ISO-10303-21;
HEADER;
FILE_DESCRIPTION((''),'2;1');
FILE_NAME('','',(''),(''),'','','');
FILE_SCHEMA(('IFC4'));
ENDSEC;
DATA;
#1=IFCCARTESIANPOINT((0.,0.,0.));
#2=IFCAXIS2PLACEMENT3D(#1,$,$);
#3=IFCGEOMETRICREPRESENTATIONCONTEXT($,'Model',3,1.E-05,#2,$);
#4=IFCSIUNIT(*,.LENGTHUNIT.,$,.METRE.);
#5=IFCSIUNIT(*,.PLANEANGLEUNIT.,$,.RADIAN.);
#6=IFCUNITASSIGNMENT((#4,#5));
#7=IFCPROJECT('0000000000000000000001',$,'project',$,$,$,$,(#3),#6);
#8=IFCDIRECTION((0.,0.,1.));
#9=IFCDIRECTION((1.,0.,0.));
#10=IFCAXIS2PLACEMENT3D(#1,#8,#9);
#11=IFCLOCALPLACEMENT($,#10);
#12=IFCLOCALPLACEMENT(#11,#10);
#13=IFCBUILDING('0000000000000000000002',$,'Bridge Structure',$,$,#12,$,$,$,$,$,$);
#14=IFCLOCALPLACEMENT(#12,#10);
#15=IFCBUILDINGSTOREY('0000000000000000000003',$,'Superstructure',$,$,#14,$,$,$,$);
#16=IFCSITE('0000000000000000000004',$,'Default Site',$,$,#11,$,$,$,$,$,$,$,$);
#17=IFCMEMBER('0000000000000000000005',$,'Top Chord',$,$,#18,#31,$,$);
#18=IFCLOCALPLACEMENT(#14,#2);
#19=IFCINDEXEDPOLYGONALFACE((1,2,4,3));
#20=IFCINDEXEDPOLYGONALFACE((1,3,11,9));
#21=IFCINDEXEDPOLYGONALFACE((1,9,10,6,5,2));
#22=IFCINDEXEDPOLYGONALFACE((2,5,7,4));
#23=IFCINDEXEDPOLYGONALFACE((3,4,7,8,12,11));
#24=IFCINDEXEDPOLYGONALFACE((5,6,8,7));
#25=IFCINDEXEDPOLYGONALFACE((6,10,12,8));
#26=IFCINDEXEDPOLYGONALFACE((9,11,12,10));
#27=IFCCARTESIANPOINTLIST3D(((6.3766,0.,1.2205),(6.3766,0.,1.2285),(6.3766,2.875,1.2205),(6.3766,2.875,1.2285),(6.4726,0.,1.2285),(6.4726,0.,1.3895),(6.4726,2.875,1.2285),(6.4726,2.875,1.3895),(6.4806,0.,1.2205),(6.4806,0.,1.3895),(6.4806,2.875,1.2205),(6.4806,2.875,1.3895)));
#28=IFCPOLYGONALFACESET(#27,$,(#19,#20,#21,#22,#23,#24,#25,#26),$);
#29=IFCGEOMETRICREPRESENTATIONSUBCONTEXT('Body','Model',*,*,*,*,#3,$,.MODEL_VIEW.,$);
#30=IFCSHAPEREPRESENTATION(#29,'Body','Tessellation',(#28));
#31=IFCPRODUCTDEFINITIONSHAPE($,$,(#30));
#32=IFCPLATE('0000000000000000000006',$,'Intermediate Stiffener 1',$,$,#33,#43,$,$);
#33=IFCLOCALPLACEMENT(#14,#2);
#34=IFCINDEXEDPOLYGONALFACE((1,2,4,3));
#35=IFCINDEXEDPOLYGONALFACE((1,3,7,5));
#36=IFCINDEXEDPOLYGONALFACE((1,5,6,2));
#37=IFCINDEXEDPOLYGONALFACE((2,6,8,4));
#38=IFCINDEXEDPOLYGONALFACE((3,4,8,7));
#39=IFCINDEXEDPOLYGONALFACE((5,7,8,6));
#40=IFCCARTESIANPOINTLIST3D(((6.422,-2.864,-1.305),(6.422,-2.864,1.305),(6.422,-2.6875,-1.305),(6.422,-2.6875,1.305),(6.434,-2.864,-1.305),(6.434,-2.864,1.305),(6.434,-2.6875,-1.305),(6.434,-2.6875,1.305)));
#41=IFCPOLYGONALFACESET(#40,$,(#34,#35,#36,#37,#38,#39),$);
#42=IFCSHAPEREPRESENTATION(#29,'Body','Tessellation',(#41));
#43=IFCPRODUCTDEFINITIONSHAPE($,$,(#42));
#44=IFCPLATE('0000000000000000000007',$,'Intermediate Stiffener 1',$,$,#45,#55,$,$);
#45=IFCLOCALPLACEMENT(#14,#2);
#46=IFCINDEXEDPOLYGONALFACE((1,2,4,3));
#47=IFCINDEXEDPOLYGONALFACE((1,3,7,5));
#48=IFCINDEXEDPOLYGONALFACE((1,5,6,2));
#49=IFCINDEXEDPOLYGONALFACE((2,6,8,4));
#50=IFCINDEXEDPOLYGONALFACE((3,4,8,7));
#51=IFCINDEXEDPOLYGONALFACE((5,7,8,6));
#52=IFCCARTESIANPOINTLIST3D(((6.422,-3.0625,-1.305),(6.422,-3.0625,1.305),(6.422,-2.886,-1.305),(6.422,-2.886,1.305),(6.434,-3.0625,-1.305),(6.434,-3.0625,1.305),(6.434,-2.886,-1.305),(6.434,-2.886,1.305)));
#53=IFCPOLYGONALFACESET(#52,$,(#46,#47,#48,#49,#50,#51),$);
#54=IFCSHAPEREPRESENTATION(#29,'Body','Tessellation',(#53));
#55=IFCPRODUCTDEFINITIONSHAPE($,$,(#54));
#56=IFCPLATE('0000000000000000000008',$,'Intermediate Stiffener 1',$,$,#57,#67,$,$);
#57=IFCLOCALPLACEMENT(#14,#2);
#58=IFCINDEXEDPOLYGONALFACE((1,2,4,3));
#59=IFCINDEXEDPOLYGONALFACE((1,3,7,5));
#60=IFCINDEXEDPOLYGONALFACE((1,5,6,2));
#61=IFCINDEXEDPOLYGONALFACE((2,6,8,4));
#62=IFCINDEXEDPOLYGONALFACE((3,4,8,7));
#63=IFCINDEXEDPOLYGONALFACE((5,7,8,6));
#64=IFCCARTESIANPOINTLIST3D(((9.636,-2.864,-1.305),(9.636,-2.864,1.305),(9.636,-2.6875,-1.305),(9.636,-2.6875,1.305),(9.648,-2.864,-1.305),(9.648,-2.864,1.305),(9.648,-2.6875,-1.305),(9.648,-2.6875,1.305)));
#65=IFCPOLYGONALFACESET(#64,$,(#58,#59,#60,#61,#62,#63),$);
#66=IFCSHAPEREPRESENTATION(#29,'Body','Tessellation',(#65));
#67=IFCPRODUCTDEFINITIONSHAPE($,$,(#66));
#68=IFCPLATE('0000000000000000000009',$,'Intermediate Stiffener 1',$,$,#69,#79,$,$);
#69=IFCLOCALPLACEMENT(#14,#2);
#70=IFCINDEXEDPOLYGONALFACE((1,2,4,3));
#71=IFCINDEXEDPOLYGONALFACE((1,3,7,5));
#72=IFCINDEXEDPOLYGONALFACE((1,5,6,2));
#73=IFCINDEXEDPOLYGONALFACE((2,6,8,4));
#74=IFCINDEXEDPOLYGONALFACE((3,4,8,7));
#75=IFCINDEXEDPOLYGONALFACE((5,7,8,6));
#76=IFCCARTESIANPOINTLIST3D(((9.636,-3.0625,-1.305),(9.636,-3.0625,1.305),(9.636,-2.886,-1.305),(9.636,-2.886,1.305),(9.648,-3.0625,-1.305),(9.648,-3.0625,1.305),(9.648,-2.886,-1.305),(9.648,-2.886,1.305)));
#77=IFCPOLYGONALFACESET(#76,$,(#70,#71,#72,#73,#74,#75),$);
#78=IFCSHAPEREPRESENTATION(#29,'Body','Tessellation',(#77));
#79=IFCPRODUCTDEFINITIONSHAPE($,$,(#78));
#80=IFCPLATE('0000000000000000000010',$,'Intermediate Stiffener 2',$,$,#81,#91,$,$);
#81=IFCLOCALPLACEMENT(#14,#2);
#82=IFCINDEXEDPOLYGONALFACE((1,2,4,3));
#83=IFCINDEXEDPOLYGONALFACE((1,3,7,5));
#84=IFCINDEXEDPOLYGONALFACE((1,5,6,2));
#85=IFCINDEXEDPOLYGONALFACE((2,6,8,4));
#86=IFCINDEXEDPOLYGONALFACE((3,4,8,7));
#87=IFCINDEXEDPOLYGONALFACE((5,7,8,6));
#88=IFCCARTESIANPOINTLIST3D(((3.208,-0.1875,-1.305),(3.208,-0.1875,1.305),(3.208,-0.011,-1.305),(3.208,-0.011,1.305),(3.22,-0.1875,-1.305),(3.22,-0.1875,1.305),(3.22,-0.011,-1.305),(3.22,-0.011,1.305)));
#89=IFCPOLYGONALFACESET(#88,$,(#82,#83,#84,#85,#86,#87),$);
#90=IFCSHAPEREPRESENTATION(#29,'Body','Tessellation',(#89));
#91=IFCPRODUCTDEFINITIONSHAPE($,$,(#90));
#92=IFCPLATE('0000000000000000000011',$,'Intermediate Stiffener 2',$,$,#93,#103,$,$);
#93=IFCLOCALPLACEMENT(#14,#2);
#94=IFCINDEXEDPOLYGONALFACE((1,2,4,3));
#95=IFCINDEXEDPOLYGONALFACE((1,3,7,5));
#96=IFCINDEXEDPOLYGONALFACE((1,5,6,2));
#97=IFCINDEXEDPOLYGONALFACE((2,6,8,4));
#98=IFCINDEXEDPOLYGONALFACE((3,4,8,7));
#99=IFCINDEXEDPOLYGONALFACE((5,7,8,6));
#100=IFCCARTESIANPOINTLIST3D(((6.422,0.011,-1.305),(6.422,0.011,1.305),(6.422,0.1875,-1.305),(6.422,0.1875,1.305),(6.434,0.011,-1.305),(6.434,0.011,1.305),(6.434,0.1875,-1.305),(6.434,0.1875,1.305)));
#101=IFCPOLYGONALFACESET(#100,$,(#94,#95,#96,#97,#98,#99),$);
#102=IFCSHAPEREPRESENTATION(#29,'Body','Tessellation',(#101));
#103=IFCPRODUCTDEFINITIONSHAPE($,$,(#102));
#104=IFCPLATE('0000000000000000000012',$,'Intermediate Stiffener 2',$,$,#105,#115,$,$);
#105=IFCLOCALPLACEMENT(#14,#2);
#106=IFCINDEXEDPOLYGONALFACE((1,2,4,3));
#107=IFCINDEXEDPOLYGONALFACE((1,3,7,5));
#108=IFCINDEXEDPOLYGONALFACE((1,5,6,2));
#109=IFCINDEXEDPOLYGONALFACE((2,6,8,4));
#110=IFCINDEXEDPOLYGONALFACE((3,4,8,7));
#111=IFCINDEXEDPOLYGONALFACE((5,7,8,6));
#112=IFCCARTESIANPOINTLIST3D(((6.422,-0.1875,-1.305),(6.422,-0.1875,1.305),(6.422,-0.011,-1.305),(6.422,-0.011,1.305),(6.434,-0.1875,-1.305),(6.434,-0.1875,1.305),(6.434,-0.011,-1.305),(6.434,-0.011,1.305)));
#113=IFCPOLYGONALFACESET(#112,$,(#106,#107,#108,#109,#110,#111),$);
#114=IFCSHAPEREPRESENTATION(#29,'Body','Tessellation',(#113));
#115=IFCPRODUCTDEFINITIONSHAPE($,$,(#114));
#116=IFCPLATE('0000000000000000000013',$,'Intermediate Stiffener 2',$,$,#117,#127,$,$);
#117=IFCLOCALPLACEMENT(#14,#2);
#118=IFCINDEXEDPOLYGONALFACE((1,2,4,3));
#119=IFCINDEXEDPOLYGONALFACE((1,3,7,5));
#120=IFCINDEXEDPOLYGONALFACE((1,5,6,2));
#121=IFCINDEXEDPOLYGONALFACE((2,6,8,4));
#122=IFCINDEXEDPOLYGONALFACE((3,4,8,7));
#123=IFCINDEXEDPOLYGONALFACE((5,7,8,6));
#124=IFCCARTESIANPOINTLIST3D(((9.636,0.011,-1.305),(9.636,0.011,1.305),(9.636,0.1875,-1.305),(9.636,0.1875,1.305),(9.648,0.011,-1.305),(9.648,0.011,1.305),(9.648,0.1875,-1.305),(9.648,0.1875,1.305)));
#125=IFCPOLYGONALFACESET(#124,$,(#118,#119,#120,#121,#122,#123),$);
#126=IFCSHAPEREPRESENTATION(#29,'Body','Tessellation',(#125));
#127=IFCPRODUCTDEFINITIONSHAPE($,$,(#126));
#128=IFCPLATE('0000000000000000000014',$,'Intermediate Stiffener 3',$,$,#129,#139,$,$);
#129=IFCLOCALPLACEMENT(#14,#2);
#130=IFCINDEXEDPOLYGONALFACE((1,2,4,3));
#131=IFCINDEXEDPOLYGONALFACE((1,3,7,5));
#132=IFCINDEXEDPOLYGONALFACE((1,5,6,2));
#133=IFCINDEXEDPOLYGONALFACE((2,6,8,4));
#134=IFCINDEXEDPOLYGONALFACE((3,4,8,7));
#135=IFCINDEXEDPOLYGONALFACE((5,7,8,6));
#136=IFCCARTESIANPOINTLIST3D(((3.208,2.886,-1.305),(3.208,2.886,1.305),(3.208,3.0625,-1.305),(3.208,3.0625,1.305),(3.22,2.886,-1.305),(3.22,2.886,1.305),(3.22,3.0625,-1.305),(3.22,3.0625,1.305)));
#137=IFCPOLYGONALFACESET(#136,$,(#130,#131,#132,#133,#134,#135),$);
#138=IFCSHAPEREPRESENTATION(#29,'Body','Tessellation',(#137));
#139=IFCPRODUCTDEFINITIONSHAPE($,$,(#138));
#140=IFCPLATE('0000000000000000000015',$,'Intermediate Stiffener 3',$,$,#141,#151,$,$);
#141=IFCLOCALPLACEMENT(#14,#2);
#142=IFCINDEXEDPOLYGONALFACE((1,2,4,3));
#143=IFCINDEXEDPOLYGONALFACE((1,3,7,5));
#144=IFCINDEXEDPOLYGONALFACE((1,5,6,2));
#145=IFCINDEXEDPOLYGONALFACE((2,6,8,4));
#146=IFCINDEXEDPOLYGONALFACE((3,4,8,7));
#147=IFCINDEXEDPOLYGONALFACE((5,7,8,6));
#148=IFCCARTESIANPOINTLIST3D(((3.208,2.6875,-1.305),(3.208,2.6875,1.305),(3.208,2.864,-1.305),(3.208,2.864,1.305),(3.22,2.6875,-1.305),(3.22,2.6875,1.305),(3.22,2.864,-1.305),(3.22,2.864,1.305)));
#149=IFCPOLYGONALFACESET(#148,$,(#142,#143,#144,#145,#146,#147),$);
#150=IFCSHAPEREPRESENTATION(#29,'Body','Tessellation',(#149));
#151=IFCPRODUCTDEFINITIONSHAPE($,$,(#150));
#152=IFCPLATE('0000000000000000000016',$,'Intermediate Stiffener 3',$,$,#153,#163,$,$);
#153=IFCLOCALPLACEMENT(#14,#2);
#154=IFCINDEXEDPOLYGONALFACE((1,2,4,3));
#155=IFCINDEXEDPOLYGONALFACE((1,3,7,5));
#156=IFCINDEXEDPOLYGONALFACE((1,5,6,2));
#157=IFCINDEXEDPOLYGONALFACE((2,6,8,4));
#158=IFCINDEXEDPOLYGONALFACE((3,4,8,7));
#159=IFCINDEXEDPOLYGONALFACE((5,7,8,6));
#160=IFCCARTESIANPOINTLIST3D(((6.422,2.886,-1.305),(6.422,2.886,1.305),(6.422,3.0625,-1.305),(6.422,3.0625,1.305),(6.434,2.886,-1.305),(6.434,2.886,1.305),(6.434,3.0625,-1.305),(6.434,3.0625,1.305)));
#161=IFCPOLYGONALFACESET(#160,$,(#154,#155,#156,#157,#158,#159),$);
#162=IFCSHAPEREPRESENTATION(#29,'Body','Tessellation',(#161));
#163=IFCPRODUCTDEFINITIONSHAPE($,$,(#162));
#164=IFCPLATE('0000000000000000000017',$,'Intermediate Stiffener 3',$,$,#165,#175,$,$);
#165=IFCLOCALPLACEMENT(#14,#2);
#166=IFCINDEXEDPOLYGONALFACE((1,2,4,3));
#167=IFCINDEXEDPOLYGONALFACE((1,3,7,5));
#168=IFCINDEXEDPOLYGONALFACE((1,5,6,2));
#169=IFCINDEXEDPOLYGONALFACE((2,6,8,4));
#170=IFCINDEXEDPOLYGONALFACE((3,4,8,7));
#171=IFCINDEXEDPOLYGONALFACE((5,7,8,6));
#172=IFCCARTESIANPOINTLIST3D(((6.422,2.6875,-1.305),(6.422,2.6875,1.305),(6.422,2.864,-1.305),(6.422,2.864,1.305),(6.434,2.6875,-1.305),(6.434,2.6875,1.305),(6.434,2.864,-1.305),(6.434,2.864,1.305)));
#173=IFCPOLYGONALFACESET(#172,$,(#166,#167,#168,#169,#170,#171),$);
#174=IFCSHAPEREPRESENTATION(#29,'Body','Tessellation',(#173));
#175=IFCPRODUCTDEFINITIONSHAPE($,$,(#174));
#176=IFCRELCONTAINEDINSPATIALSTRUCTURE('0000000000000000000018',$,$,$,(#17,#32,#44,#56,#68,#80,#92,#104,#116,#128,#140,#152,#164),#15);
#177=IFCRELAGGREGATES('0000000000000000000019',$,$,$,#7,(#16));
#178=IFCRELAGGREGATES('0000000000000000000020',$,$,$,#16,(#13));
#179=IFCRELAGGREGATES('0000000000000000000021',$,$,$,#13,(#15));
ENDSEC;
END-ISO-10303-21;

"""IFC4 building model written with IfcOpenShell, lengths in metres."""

from ifc_helpers import new_model, si_unit, frame, origin, origin_with_axes, origin_2d_with_axis, place, context, subcontext, project, spatial, rectangle, l_section, extrude, element, save


model = new_model("IFC4")

# Units and contexts
model_context = context("Model", 3, precision=1e-05, world=origin())
body_context = subcontext(model_context, "Body", "Model", "MODEL_VIEW")
ifc_project = project(units=[si_unit("LENGTHUNIT", "METRE"), si_unit("PLANEANGLEUNIT", "RADIAN")], contexts=[model_context])

# Site, building, storey
site_placement = place(None, origin_with_axes())
site = spatial("IfcSite", under=ifc_project, at=site_placement, Name="Default Site")
building_placement = place(site_placement, origin_with_axes())
building = spatial("IfcBuilding", under=site, at=building_placement, Name="Bridge Structure")
storey_placement = place(building_placement, origin_with_axes())
storey = spatial("IfcBuildingStorey", under=building, at=storey_placement, Name="Superstructure")

# Member
for number, where, z_axis, x_axis, name in (
    (1, (6.4286, 0.0, 1.305), (0.0, 1.0, 0.0), (-1.0, 0.0, 0.0), "Top Chord"),
):
    element("IfcMember", number, at=place(storey_placement, frame(where, z_axis=z_axis, x_axis=x_axis)), inside=storey, Name=name, context=body_context, shape_type="SweptSolid", body=[
        extrude(l_section(Depth=0.169, Width=0.104, Thickness=0.008, at=origin_2d_with_axis()), origin_with_axes(), (0.0, 0.0, 1.0), 2.875),
    ])

# Plates
for number, where, z_axis, x_axis, name in (
    (2, (6.428, -2.7757, -1.305), (0.0, 0.0, 1.0), (1.0, 0.0, 0.0), "Intermediate Stiffener 1"),
    (3, (6.428, -2.9743, -1.305), (0.0, 0.0, 1.0), (1.0, 0.0, 0.0), "Intermediate Stiffener 1"),
    (4, (9.642, -2.7757, -1.305), (0.0, 0.0, 1.0), (1.0, 0.0, 0.0), "Intermediate Stiffener 1"),
    (5, (9.642, -2.9743, -1.305), (0.0, 0.0, 1.0), (1.0, 0.0, 0.0), "Intermediate Stiffener 1"),
    (6, (3.214, -0.0993, -1.305), (0.0, 0.0, 1.0), (1.0, 0.0, 0.0), "Intermediate Stiffener 2"),
    (7, (6.428, 0.0993, -1.305), (0.0, 0.0, 1.0), (1.0, 0.0, 0.0), "Intermediate Stiffener 2"),
    (8, (6.428, -0.0993, -1.305), (0.0, 0.0, 1.0), (1.0, 0.0, 0.0), "Intermediate Stiffener 2"),
    (9, (9.642, 0.0993, -1.305), (0.0, 0.0, 1.0), (1.0, 0.0, 0.0), "Intermediate Stiffener 2"),
    (10, (3.214, 2.9743, -1.305), (0.0, 0.0, 1.0), (1.0, 0.0, 0.0), "Intermediate Stiffener 3"),
    (11, (3.214, 2.7757, -1.305), (0.0, 0.0, 1.0), (1.0, 0.0, 0.0), "Intermediate Stiffener 3"),
    (12, (6.428, 2.9743, -1.305), (0.0, 0.0, 1.0), (1.0, 0.0, 0.0), "Intermediate Stiffener 3"),
    (13, (6.428, 2.7757, -1.305), (0.0, 0.0, 1.0), (1.0, 0.0, 0.0), "Intermediate Stiffener 3"),
):
    element("IfcPlate", number, at=place(storey_placement, frame(where, z_axis=z_axis, x_axis=x_axis)), inside=storey, Name=name, context=body_context, shape_type="SweptSolid", body=[
        extrude(rectangle(XDim=0.012, YDim=0.1765, at=origin_2d_with_axis()), origin_with_axes(), (0.0, 0.0, 1.0), 2.61),
    ])

save(model, "model.ifc")
